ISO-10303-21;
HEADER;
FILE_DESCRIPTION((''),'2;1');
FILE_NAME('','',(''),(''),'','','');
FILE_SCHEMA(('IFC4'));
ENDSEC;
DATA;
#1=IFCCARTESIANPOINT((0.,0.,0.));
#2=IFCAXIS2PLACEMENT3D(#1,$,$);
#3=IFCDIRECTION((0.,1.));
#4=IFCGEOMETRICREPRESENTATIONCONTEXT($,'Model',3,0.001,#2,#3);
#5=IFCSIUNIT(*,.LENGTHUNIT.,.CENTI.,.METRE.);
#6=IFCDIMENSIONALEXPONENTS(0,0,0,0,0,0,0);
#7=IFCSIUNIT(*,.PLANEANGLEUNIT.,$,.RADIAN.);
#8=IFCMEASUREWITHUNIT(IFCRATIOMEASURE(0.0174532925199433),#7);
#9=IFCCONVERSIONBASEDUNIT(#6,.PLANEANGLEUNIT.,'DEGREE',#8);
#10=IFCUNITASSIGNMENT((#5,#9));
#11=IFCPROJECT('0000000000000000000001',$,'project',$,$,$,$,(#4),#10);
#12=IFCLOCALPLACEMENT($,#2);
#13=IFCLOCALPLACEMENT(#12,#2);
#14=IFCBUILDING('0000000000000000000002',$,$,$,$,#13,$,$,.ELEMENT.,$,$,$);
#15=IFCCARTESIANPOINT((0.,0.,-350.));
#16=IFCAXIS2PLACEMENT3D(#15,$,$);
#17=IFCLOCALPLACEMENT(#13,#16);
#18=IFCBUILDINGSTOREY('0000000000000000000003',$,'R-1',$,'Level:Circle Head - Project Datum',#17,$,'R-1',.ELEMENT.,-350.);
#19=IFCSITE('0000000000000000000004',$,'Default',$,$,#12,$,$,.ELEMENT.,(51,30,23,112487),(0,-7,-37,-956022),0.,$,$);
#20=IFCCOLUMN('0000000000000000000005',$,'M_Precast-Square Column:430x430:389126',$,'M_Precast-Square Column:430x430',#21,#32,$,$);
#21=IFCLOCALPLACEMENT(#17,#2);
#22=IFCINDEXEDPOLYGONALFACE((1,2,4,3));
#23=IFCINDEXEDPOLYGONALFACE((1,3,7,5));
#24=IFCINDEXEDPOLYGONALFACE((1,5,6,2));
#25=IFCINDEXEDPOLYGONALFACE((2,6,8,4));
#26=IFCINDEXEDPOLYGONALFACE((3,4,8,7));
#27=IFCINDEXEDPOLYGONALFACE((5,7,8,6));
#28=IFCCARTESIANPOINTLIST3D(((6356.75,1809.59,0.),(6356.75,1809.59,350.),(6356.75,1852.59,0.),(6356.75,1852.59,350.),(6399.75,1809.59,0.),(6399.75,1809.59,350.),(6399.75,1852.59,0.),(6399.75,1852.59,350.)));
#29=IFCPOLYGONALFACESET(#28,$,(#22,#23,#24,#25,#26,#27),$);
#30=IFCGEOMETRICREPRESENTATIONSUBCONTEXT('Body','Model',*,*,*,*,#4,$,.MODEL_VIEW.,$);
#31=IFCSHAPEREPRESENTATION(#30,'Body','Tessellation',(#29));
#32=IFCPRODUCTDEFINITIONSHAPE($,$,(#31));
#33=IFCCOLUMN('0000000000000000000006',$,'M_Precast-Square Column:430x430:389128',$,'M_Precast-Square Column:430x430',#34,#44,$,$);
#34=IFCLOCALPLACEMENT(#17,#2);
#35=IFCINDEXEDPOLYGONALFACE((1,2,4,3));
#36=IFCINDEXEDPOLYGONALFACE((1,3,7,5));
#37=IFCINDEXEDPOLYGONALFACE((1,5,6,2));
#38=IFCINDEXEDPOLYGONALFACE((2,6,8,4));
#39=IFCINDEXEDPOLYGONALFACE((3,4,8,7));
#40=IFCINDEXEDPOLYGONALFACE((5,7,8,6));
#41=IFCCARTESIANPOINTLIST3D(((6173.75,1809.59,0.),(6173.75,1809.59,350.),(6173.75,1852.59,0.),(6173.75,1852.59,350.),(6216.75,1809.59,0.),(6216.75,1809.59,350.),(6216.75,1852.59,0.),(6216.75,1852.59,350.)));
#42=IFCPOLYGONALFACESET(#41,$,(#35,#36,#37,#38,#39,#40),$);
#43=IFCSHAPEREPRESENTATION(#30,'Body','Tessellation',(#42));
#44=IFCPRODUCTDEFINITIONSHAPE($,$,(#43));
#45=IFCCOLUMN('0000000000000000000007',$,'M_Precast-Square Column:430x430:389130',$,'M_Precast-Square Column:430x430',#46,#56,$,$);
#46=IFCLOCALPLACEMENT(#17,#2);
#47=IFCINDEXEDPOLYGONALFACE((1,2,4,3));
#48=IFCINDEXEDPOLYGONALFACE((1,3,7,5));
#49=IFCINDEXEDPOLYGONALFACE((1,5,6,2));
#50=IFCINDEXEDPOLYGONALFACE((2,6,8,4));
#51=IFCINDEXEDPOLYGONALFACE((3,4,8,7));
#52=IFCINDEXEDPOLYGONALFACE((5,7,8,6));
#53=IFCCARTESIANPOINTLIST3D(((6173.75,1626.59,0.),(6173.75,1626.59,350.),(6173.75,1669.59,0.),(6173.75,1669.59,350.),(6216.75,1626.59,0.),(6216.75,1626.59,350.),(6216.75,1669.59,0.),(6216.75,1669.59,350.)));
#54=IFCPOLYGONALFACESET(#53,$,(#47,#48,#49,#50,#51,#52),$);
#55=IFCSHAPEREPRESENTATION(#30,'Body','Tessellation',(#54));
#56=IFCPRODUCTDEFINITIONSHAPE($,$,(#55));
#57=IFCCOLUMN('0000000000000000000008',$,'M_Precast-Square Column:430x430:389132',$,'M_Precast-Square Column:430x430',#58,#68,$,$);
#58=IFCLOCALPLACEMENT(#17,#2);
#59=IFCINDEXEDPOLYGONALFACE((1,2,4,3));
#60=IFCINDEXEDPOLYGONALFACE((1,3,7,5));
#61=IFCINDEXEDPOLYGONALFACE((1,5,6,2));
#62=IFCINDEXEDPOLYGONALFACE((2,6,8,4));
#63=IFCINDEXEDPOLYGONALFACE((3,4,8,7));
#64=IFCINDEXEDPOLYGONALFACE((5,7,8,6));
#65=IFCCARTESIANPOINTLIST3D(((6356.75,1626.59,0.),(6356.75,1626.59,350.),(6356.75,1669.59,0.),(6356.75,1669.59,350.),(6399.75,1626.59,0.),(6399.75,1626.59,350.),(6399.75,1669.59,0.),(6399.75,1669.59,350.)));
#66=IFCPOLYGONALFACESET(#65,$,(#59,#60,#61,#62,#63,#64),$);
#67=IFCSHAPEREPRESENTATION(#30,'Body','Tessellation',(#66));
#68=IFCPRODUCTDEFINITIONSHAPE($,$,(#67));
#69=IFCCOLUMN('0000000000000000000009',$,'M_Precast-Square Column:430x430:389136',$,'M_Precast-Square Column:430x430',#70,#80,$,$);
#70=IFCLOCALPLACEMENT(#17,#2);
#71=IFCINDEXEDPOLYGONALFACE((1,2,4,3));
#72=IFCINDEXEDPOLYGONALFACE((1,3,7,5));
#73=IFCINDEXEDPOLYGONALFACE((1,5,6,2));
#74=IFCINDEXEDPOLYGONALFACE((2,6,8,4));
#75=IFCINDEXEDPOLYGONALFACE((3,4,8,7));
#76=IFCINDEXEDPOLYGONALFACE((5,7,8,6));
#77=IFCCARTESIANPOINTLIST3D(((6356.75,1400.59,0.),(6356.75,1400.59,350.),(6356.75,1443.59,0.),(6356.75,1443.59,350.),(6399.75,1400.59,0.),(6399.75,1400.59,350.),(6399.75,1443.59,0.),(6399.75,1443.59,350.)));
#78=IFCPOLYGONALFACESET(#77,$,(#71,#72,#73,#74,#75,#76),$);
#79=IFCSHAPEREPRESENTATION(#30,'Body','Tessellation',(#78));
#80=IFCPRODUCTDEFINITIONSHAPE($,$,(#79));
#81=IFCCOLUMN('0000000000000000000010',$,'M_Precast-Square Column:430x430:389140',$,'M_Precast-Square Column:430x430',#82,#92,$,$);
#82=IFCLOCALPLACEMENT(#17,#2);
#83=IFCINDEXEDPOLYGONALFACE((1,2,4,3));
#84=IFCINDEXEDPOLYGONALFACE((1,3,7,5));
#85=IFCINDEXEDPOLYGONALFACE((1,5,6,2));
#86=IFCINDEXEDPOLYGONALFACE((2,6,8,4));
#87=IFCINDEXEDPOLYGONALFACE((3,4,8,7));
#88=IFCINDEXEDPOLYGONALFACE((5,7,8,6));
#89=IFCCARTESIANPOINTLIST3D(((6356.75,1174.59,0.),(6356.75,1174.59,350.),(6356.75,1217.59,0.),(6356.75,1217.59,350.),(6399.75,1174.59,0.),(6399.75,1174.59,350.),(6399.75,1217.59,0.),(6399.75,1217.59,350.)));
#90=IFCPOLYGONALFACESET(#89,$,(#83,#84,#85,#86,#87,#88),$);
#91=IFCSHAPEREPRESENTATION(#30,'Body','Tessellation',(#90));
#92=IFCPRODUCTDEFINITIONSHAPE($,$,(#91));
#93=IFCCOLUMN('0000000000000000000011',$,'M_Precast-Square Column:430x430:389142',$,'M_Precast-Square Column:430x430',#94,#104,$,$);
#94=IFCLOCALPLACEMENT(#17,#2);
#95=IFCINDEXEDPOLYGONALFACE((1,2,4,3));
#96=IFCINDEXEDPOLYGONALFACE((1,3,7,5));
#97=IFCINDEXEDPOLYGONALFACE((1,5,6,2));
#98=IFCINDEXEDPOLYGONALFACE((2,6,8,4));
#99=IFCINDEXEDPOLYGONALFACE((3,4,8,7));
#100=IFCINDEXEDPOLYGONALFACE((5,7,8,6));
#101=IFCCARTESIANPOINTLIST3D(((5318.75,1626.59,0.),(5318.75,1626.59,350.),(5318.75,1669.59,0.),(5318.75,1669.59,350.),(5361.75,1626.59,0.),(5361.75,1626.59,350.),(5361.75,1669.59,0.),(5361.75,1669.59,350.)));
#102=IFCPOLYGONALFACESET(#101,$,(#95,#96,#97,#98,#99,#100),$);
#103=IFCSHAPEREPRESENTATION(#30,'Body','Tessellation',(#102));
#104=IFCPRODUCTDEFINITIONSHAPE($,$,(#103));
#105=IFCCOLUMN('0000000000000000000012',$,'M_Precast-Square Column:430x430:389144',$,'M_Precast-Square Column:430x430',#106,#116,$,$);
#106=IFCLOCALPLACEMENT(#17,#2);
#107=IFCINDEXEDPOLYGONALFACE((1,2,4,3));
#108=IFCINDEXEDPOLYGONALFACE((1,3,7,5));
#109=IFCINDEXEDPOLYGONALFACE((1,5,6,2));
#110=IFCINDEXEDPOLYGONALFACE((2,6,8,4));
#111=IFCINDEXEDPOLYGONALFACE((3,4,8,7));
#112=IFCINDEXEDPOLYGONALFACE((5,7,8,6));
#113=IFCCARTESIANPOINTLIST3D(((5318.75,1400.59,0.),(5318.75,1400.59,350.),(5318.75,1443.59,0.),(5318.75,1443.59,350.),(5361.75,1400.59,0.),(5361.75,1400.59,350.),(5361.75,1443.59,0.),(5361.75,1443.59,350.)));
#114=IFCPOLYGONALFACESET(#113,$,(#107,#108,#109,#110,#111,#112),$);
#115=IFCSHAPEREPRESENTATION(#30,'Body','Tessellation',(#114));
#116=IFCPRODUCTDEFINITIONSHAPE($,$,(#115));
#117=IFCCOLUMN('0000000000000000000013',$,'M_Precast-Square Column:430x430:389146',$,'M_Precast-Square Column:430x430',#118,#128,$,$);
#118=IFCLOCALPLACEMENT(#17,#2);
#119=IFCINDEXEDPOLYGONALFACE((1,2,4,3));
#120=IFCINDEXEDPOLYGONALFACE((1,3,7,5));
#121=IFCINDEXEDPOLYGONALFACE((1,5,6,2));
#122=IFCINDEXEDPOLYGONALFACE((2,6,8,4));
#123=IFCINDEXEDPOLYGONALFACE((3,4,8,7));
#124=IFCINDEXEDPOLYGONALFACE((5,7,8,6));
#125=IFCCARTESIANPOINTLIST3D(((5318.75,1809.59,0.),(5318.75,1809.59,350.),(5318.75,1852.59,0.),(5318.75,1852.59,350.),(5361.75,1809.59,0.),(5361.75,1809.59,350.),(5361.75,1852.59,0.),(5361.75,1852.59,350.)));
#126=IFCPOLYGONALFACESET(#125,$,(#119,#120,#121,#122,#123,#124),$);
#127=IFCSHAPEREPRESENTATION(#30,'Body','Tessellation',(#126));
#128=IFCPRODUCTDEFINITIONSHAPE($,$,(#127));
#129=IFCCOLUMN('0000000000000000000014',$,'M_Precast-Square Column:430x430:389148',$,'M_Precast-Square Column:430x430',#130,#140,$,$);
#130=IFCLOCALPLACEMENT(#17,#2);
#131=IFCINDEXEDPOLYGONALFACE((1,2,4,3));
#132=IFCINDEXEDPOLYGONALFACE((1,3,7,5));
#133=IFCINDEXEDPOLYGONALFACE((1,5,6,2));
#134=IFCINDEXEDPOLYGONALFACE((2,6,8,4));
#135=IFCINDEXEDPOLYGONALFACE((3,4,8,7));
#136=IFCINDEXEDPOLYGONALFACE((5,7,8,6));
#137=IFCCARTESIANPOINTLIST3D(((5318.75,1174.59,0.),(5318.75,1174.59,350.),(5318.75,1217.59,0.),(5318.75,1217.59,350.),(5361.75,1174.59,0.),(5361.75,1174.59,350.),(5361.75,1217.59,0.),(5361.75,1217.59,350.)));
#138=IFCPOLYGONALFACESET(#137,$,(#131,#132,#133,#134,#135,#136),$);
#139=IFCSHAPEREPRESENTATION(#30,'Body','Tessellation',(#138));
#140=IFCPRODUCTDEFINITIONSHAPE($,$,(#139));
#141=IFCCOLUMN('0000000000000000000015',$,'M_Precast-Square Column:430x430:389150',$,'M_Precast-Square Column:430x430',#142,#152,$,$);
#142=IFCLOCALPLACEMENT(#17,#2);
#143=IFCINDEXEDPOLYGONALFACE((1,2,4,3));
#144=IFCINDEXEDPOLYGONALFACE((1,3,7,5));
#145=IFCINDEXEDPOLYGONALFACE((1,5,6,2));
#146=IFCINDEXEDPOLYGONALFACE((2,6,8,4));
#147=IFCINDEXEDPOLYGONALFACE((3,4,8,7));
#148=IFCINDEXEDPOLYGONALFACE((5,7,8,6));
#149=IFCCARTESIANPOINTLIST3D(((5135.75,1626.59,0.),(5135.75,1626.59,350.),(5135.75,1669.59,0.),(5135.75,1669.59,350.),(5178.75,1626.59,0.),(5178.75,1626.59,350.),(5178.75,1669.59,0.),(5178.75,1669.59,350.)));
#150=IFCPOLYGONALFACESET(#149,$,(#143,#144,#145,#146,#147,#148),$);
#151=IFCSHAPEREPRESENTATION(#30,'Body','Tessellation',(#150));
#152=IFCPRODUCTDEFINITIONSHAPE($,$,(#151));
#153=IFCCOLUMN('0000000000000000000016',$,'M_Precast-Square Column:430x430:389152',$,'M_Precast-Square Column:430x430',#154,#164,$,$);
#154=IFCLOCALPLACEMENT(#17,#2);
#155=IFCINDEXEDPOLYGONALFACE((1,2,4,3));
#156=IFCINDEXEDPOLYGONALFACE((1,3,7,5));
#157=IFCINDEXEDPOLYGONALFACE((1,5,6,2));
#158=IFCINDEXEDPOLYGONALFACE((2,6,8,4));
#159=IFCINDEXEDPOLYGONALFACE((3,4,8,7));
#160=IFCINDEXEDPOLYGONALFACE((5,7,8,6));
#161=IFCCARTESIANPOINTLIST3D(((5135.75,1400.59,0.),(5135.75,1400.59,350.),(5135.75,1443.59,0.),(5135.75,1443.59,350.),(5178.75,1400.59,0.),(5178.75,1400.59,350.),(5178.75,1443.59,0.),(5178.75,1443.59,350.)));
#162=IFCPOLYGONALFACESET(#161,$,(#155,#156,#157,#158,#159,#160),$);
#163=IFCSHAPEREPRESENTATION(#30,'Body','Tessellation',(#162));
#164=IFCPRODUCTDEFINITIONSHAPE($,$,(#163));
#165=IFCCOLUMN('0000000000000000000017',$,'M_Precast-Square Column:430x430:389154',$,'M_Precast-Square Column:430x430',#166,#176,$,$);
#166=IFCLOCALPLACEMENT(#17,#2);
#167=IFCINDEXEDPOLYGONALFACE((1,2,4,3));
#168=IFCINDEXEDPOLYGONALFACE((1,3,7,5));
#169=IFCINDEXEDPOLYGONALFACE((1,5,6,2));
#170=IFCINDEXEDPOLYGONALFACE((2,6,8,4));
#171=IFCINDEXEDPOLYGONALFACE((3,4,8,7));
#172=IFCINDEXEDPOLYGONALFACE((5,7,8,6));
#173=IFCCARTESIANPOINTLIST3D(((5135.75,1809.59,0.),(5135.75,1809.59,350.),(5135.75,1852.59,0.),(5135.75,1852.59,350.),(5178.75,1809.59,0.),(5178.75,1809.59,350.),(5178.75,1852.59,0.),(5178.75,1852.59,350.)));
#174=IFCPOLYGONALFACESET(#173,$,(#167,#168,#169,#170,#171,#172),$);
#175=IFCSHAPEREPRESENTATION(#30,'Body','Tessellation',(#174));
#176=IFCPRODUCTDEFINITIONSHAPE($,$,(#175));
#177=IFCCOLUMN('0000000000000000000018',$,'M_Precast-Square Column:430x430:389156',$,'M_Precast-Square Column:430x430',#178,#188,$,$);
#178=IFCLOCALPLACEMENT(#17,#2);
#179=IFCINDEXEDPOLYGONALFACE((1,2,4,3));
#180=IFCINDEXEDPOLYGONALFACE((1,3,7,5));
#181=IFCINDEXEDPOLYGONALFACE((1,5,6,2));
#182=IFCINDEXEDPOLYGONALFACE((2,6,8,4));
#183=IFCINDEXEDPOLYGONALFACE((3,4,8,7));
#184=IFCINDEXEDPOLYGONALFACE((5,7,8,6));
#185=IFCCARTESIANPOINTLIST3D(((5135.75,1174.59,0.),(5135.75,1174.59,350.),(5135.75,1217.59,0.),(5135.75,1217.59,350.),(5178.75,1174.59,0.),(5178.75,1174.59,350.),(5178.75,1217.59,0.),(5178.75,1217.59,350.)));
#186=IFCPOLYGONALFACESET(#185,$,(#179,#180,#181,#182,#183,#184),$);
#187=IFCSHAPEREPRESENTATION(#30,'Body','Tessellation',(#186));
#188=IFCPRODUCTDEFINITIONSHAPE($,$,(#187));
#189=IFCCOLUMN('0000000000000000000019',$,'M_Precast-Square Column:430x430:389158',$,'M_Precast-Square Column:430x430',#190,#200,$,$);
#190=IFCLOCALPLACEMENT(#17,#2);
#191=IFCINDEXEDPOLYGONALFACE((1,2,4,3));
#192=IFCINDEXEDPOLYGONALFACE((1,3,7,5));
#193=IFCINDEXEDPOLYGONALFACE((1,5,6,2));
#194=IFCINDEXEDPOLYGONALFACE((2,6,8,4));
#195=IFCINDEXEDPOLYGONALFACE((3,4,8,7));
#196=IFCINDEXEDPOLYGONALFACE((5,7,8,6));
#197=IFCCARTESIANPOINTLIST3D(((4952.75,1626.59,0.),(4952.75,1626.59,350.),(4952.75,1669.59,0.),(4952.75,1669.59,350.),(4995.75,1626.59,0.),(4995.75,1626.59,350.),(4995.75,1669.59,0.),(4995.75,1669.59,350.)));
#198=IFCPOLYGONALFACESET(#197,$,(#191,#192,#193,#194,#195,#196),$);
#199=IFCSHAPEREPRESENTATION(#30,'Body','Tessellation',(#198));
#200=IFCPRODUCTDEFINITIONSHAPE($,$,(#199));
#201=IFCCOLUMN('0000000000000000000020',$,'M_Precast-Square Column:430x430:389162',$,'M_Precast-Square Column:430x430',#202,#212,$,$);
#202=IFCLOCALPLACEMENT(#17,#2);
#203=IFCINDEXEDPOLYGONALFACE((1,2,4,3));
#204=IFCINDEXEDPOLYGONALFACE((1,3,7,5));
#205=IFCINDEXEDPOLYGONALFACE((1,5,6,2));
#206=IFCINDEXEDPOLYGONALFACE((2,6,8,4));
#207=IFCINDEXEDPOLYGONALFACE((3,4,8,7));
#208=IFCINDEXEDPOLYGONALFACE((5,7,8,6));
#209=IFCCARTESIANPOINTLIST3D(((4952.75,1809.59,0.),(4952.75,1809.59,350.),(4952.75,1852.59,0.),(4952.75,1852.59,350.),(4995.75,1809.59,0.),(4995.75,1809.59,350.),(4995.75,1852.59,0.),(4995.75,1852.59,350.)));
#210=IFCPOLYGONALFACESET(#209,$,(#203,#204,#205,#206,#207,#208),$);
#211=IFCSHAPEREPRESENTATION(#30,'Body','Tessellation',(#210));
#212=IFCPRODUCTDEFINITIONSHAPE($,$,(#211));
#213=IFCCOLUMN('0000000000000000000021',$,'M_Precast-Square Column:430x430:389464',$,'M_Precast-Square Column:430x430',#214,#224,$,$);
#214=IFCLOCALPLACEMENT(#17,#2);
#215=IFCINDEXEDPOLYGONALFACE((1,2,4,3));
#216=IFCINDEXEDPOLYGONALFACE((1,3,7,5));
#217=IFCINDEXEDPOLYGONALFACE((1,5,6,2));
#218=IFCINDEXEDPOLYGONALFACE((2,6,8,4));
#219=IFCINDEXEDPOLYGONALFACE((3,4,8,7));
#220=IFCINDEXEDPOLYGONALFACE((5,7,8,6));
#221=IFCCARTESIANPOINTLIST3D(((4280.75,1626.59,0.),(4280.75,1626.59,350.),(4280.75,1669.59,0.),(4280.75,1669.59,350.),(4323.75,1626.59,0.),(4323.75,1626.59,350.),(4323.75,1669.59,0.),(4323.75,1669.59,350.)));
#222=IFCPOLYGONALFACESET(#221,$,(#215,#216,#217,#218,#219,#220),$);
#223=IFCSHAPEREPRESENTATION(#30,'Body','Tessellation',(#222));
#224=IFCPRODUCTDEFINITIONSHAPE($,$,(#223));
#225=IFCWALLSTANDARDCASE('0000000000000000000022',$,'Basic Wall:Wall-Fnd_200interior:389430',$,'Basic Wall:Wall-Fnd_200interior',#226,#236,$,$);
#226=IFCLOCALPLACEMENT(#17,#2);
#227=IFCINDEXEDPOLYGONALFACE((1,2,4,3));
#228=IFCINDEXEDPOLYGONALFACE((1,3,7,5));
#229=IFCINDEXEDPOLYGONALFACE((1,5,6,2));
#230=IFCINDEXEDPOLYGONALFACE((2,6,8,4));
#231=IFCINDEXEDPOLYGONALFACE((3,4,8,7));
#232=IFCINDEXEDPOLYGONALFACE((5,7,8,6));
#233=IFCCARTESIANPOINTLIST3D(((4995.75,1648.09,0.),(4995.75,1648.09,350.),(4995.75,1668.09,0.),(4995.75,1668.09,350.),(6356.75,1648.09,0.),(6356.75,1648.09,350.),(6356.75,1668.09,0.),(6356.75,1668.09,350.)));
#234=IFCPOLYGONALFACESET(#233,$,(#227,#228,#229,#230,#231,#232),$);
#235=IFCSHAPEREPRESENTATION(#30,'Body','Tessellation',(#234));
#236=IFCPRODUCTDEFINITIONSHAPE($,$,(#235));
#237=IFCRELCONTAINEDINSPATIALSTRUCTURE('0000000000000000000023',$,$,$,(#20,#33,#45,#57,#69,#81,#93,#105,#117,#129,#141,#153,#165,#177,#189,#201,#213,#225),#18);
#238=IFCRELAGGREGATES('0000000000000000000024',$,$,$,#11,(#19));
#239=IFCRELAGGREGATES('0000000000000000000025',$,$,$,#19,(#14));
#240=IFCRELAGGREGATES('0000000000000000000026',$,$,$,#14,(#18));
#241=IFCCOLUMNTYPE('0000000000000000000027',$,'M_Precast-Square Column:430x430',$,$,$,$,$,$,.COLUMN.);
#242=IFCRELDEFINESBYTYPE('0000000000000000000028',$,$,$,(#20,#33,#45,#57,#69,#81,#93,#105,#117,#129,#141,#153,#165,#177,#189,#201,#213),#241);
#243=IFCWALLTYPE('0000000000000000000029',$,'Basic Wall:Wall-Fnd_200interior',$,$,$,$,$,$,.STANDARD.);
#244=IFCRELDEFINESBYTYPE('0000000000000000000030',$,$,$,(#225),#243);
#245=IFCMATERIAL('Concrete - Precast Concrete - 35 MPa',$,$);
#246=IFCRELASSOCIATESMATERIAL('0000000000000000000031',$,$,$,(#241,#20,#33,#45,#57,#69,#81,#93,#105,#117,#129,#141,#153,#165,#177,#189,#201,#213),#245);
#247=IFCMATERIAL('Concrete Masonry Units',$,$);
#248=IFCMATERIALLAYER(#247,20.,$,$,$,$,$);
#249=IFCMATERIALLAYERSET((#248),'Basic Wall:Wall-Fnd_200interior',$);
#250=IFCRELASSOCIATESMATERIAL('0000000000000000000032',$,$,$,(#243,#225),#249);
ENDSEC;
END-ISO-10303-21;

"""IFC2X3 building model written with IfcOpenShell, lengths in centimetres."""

from ifc_helpers import new_model, entity, si_unit, converted_unit, direction, frame, frame_2d, origin, origin_2d_with_axis, place, context, subcontext, project, spatial, rectangle, extrude, source, transform, mapped, material, layer, layer_set, layer_usage, type_object, type_shapes, element, save


model = new_model("IFC2X3")

# Units and contexts
model_context = context("Model", 3, precision=0.001, world=origin(), true_north=direction((0.0, 1.0)))
body_context = subcontext(model_context, "Body", "Model", "MODEL_VIEW")
ifc_project = project(units=[si_unit("LENGTHUNIT", "METRE", prefix="CENTI"), converted_unit("PLANEANGLEUNIT", "DEGREE", entity("IfcRatioMeasure", 0.0174532925199433), si_unit("PLANEANGLEUNIT", "RADIAN"), dimensions=[0, 0, 0, 0, 0, 0, 0])], contexts=[model_context])

# Site, building, storey
site_placement = place(None, origin())
site = spatial("IfcSite", under=ifc_project, at=site_placement, Name="Default", CompositionType="ELEMENT", RefLatitude=(51, 30, 23, 112487), RefLongitude=(0, -7, -37, -956022), RefElevation=0.0)
building_placement = place(site_placement, origin())
building = spatial("IfcBuilding", under=site, at=building_placement, CompositionType="ELEMENT")
storey_placement = place(building_placement, frame((0.0, 0.0, -350.0)))
storey = spatial("IfcBuildingStorey", under=building, at=storey_placement, Name="R-1", ObjectType="Level:Circle Head - Project Datum", LongName="R-1", CompositionType="ELEMENT", Elevation=-350.0)

# Columns
ifc_material_1 = material(Name="Concrete - Precast Concrete - 35 MPa")
column_type = type_object("IfcColumnType", Name="M_Precast-Square Column:430x430", PredefinedType="COLUMN", material=ifc_material_1)
shared_shape = source(origin(), body_context, "Body", "SweptSolid", [
    extrude(rectangle(XDim=43.0, YDim=43.0, at=origin_2d_with_axis()), frame((0.0, 0.0, -350.0), z_axis=(0.0, 0.0, 1.0), x_axis=(0.0, -1.0, 0.0)), (0.0, 0.0, 1.0), 350.0),
])
type_shapes(column_type, [shared_shape])
for number, where, name in (
    (1, (6378.25, 1831.09, 350.0), "M_Precast-Square Column:430x430:389126"),
    (2, (6195.25, 1831.09, 350.0), "M_Precast-Square Column:430x430:389128"),
    (3, (6195.25, 1648.09, 350.0), "M_Precast-Square Column:430x430:389130"),
    (4, (6378.25, 1648.09, 350.0), "M_Precast-Square Column:430x430:389132"),
    (5, (6378.25, 1422.09, 350.0), "M_Precast-Square Column:430x430:389136"),
    (6, (6378.25, 1196.09, 350.0), "M_Precast-Square Column:430x430:389140"),
    (7, (5340.25, 1648.09, 350.0), "M_Precast-Square Column:430x430:389142"),
    (8, (5340.25, 1422.09, 350.0), "M_Precast-Square Column:430x430:389144"),
    (9, (5340.25, 1831.09, 350.0), "M_Precast-Square Column:430x430:389146"),
    (10, (5340.25, 1196.09, 350.0), "M_Precast-Square Column:430x430:389148"),
    (11, (5157.25, 1648.09, 350.0), "M_Precast-Square Column:430x430:389150"),
    (12, (5157.25, 1422.09, 350.0), "M_Precast-Square Column:430x430:389152"),
    (13, (5157.25, 1831.09, 350.0), "M_Precast-Square Column:430x430:389154"),
    (14, (5157.25, 1196.09, 350.0), "M_Precast-Square Column:430x430:389156"),
    (15, (4974.25, 1648.09, 350.0), "M_Precast-Square Column:430x430:389158"),
    (16, (4974.25, 1831.09, 350.0), "M_Precast-Square Column:430x430:389162"),
    (17, (4302.25, 1648.09, 350.0), "M_Precast-Square Column:430x430:389464"),
):
    element("IfcColumn", number, at=place(storey_placement, frame(where)), inside=storey, type_object=column_type, material=ifc_material_1, Name=name, ObjectType="M_Precast-Square Column:430x430", context=body_context, shape_type="MappedRepresentation", body=[
        mapped(shared_shape, transform((0.0, 0.0, 0.0), scale=1.0)),
    ])

# Wall
ifc_material_2 = material(Name="Concrete Masonry Units")
ifc_layer_1 = layer(ifc_material_2, 20.0)
ifc_layer_set_1 = layer_set([ifc_layer_1], Name="Basic Wall:Wall-Fnd_200interior")
ifc_layer_usage_1 = layer_usage(ifc_layer_set_1, "AXIS2", "NEGATIVE", 10.0)
wall_type_1 = type_object("IfcWallType", Name="Basic Wall:Wall-Fnd_200interior", PredefinedType="STANDARD", material=ifc_layer_set_1)
wall_1_placement = place(storey_placement, frame((6356.75, 1658.09, 0.0), z_axis=(0.0, 0.0, 1.0), x_axis=(-1.0, 0.0, 0.0)))
element("IfcWallStandardCase", 18, at=wall_1_placement, inside=storey, type_object=wall_type_1, material=ifc_layer_usage_1, Name="Basic Wall:Wall-Fnd_200interior:389430", ObjectType="Basic Wall:Wall-Fnd_200interior", context=body_context, shape_type="SweptSolid", body=[
    extrude(rectangle(XDim=1361.0, YDim=20.0, at=frame_2d((680.5, 0.0), x_axis=(-1.0, 0.0))), origin(), (0.0, 0.0, 1.0), 350.0),
])

save(model, "model.ifc")
